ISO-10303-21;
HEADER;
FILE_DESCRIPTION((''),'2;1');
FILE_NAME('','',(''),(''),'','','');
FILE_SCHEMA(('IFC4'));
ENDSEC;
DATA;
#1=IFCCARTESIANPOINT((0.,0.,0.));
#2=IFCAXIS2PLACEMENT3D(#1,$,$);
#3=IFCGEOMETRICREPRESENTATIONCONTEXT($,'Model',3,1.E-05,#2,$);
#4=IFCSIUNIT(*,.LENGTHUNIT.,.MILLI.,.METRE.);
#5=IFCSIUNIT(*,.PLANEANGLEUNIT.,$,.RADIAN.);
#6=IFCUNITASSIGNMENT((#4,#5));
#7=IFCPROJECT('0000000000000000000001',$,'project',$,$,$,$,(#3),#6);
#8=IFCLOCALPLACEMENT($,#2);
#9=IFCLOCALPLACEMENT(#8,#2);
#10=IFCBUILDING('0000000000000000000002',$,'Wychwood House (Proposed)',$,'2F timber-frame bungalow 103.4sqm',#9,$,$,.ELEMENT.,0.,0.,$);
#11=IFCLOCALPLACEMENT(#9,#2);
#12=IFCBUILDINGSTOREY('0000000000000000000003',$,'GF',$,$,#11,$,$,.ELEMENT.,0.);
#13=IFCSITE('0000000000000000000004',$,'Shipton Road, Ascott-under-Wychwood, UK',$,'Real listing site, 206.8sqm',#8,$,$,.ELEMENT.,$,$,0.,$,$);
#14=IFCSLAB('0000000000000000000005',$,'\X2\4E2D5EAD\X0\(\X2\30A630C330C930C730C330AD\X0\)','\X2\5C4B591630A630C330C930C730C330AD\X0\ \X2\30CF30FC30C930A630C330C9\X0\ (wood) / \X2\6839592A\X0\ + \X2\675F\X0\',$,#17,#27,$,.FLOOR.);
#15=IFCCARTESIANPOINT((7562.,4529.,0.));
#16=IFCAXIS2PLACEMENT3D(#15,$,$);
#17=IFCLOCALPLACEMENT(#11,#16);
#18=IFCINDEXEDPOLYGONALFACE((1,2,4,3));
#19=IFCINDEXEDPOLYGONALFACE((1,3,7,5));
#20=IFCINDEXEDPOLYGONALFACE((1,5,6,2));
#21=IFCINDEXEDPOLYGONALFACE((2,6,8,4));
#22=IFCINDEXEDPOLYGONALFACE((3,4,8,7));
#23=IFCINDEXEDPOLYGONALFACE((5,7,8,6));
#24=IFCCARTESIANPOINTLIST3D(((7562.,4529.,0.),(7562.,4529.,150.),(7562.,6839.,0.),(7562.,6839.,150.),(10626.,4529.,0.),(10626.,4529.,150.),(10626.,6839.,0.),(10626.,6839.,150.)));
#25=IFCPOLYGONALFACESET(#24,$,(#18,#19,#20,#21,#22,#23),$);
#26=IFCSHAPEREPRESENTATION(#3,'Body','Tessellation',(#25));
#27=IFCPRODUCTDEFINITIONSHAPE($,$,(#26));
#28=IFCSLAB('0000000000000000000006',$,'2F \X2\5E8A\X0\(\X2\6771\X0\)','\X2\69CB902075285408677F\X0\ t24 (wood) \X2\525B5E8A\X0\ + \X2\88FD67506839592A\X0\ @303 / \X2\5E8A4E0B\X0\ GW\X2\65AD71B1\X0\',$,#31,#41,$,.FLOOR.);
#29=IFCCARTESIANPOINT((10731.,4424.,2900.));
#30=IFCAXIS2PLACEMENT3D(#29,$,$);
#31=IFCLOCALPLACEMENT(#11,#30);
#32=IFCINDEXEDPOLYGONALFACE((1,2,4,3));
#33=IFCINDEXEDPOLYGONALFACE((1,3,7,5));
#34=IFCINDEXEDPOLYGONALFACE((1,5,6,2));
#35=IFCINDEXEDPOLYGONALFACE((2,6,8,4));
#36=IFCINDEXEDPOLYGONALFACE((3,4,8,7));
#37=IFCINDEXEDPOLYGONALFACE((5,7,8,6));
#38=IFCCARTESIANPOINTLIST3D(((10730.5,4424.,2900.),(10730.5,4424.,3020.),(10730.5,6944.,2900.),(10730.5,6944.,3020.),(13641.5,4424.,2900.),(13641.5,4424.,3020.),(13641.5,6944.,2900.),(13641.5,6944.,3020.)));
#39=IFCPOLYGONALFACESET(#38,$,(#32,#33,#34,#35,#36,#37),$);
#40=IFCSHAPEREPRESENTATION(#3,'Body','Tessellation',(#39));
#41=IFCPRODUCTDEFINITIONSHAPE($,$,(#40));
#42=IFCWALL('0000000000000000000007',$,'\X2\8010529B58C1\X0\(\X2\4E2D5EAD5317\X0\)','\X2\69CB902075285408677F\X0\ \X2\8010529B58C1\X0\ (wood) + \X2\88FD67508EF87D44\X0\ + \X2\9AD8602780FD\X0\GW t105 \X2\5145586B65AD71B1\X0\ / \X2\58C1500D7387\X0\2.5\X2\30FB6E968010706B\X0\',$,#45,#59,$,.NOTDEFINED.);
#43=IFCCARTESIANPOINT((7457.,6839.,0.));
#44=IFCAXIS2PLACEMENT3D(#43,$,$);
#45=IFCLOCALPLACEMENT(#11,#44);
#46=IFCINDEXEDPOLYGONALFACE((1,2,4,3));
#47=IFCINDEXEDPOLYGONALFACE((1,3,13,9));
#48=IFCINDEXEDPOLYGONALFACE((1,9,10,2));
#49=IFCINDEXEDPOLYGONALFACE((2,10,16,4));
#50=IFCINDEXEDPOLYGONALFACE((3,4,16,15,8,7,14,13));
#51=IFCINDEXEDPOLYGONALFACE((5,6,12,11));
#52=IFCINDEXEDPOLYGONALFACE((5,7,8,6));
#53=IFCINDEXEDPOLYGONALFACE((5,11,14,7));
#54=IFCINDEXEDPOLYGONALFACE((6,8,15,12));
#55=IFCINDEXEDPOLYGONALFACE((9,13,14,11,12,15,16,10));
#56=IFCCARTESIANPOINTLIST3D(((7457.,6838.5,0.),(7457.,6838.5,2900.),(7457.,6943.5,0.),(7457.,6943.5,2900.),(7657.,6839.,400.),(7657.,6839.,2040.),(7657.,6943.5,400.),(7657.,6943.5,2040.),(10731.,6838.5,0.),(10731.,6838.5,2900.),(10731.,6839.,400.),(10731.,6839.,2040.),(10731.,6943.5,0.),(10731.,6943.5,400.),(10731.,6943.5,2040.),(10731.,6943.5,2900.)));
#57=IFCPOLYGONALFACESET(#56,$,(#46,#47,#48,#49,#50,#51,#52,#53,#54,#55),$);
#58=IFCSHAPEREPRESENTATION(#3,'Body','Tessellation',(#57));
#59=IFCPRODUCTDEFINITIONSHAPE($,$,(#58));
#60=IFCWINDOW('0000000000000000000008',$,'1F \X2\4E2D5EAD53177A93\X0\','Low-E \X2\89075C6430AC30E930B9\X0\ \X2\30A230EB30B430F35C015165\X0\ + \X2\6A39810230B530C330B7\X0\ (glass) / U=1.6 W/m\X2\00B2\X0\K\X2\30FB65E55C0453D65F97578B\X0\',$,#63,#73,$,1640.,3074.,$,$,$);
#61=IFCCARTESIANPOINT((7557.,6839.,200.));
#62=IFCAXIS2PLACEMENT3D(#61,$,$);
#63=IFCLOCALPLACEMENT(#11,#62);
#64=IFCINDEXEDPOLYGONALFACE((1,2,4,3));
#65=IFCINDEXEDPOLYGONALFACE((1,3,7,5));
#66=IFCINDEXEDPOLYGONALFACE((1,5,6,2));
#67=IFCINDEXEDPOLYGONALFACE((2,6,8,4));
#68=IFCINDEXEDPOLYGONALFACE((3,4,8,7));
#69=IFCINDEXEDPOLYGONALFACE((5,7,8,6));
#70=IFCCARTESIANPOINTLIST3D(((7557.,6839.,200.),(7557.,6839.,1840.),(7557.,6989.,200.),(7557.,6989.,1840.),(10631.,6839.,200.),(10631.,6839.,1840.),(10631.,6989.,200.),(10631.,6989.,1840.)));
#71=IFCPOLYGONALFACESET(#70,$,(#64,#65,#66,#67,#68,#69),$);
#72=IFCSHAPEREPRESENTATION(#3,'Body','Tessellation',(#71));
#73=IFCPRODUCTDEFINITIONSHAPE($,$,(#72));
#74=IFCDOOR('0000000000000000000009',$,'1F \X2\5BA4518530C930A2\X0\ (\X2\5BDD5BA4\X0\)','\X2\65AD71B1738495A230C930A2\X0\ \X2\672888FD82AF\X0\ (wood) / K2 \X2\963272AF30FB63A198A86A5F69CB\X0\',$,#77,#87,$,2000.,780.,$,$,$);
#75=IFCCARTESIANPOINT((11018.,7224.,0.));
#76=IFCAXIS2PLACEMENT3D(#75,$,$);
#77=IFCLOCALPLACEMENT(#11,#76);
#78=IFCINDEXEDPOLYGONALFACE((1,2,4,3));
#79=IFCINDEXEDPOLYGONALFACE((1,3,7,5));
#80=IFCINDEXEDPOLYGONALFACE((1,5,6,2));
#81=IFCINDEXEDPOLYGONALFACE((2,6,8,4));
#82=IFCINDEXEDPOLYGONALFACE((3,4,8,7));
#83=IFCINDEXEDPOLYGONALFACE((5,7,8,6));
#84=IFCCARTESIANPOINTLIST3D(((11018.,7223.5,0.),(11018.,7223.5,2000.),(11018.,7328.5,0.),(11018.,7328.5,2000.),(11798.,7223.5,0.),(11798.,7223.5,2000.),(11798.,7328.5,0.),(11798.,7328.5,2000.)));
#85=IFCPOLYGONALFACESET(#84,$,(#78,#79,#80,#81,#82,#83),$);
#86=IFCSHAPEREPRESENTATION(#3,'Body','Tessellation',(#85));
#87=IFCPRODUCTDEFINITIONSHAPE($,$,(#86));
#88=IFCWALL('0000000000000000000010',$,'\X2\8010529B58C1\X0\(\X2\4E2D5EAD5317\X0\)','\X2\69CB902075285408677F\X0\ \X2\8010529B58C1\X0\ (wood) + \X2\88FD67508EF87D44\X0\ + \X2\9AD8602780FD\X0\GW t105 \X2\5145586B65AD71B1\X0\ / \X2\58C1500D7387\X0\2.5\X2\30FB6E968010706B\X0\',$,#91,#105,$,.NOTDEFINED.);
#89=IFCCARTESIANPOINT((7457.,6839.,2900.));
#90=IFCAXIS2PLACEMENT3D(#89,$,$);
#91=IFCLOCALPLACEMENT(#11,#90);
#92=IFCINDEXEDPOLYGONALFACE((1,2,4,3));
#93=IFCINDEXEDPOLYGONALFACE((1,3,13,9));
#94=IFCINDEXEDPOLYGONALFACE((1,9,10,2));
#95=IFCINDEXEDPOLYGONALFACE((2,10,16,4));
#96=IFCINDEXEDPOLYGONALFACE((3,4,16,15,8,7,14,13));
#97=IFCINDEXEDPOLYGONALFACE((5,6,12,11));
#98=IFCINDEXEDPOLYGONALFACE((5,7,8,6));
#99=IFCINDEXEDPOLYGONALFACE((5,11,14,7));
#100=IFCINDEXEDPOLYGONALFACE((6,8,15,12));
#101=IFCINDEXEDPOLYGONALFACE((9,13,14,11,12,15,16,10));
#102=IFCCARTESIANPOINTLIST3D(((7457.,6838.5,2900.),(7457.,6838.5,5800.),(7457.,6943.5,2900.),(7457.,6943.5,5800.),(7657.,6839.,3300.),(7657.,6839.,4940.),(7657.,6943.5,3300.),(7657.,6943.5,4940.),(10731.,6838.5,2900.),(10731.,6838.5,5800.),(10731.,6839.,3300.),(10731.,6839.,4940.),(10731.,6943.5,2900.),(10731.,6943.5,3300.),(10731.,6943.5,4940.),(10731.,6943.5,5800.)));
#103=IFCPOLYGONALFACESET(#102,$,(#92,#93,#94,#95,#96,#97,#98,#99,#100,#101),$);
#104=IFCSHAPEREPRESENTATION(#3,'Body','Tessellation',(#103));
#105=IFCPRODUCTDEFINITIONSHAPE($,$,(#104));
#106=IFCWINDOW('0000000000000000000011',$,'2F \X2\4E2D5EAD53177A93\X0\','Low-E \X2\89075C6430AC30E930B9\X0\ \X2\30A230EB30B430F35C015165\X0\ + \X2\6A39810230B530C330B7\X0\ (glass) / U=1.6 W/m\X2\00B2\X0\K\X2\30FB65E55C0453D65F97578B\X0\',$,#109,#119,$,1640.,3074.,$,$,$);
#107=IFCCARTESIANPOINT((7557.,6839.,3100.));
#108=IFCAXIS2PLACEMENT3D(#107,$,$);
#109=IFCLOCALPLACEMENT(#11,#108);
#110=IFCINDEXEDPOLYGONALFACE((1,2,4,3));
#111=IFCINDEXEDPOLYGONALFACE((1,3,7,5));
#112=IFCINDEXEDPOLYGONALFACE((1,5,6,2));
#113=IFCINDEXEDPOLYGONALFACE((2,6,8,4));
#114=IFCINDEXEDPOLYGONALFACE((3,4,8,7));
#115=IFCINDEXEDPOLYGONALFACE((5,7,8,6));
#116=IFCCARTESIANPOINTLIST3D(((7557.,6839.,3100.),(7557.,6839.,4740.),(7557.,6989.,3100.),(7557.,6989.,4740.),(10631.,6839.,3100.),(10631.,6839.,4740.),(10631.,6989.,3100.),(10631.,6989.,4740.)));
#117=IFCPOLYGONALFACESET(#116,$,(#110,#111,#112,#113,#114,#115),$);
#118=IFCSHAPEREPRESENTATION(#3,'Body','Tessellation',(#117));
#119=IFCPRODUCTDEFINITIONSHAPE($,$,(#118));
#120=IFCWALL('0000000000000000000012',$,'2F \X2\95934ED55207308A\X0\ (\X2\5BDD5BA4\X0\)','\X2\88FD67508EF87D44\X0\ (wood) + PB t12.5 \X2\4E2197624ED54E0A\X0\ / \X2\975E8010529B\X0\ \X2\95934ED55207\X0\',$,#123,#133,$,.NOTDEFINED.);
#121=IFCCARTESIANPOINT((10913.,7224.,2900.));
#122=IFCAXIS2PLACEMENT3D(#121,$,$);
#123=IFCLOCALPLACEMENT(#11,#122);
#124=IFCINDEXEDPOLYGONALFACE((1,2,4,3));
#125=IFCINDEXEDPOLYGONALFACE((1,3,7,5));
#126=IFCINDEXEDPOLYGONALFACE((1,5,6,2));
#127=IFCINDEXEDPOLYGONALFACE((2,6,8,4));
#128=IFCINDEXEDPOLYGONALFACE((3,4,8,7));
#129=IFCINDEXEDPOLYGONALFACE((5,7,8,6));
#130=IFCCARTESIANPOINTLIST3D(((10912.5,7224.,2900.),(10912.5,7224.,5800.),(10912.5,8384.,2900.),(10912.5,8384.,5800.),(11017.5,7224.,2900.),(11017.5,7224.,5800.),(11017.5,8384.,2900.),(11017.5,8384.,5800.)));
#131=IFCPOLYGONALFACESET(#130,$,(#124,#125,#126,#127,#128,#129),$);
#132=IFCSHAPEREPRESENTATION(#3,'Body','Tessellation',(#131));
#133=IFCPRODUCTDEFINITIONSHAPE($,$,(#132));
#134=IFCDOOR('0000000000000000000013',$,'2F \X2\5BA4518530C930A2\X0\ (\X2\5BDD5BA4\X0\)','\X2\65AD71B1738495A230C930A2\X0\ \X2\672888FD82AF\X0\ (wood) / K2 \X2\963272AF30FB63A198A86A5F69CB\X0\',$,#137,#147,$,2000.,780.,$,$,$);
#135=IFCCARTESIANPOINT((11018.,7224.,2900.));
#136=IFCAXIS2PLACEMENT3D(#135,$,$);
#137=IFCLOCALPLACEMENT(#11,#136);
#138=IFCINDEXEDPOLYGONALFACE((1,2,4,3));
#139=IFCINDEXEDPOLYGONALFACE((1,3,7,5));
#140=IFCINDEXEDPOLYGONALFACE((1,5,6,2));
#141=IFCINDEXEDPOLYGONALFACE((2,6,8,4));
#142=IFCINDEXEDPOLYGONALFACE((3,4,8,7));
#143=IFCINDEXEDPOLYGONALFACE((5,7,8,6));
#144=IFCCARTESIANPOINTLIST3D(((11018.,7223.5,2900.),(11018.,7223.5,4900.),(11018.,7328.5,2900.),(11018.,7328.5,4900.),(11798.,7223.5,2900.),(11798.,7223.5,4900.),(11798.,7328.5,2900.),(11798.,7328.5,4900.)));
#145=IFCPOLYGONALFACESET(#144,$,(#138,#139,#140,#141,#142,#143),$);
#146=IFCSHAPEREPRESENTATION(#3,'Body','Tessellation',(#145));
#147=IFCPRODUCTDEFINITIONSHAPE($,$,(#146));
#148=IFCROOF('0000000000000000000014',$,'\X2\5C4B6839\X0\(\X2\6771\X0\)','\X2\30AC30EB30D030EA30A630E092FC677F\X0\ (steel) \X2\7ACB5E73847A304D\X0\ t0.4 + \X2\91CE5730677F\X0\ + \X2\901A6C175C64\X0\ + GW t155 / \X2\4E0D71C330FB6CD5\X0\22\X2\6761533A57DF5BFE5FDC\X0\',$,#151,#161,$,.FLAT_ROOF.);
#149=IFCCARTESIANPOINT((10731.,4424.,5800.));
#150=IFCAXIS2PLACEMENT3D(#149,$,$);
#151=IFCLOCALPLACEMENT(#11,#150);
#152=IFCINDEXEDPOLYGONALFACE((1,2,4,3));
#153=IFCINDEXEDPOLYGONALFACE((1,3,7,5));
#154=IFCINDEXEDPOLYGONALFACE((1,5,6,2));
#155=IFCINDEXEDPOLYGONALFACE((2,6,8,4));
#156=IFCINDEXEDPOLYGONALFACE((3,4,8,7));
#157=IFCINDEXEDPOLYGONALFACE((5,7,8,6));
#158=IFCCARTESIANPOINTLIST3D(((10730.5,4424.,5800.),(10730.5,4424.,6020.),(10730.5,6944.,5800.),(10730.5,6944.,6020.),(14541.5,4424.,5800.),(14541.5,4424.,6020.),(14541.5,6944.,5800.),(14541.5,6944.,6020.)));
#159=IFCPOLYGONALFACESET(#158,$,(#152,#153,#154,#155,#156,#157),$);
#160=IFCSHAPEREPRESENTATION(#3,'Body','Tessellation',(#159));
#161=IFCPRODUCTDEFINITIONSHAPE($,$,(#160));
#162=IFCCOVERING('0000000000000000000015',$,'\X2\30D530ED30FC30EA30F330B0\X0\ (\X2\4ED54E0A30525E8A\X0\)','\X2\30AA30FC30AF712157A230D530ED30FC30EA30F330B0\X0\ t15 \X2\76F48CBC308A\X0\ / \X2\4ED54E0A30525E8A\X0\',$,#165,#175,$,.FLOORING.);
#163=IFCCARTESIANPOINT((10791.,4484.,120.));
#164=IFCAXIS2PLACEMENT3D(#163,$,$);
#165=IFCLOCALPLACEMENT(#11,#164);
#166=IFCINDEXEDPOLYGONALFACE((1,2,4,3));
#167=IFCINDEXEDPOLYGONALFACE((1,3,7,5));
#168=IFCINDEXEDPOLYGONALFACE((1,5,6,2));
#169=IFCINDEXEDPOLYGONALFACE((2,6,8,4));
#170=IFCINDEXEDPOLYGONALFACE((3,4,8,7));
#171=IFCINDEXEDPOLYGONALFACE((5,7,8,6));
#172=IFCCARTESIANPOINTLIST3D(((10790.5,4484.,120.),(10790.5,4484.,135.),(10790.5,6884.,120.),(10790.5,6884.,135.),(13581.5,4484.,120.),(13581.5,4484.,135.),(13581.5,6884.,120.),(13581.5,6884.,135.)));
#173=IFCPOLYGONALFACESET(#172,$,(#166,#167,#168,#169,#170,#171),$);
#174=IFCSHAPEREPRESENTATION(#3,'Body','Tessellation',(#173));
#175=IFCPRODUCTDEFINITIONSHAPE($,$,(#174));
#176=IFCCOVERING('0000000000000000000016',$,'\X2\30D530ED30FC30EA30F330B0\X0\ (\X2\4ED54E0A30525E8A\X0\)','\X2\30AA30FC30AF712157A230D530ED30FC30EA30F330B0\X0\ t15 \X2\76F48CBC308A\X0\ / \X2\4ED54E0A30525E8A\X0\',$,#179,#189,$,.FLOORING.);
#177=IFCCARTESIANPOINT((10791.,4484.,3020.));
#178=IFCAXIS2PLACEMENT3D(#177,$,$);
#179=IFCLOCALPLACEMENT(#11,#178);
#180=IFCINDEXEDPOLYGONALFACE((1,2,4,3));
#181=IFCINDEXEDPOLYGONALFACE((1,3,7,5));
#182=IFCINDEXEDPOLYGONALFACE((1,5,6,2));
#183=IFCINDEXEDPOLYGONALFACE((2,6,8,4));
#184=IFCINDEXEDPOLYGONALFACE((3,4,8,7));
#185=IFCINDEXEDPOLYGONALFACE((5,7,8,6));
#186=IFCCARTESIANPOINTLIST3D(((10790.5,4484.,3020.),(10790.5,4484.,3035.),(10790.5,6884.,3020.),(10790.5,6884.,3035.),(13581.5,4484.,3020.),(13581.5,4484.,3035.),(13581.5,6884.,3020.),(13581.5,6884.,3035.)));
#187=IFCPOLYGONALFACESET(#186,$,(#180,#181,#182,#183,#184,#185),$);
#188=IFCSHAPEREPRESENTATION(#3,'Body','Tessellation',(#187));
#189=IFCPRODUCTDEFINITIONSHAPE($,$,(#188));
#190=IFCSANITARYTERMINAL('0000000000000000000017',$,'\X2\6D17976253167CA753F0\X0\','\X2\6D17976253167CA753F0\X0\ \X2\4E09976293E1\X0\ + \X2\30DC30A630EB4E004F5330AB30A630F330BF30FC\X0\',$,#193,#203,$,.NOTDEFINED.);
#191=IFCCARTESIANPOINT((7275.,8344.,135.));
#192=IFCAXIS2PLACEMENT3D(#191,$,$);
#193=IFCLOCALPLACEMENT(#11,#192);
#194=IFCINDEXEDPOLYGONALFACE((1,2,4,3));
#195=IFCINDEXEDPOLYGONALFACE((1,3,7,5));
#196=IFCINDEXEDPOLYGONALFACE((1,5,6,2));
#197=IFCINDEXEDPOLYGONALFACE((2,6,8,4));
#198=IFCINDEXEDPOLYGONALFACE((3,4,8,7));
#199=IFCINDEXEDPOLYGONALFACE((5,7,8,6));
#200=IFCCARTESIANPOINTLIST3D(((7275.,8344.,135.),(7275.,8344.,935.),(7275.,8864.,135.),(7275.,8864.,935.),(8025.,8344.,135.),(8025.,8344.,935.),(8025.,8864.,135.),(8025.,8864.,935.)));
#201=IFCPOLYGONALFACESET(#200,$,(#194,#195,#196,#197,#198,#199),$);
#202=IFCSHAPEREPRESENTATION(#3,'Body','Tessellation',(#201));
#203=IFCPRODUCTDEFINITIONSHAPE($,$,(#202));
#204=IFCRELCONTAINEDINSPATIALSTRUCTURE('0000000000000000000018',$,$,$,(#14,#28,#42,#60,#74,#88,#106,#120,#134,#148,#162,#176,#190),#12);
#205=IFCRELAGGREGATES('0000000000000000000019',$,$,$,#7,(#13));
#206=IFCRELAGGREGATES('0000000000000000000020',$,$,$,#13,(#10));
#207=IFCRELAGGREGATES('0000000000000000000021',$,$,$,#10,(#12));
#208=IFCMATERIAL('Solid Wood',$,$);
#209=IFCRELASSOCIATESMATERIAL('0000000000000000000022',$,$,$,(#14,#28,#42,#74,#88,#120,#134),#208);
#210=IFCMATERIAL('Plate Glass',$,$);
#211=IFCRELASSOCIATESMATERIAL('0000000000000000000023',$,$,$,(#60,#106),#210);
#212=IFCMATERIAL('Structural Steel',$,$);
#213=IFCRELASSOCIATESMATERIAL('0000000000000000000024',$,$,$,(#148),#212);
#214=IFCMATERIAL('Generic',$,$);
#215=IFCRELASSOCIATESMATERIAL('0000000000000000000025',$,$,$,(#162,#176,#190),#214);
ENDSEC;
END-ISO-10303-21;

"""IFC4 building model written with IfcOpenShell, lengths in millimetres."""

from ifc_helpers import new_model, si_unit, frame, frame_2d, origin, place, context, project, spatial, rectangle, extrude, material, element, fill, save


model = new_model("IFC4")

# Units and contexts
model_context = context("Model", 3, precision=1e-05, world=origin())
ifc_project = project(units=[si_unit("LENGTHUNIT", "METRE", prefix="MILLI"), si_unit("PLANEANGLEUNIT", "RADIAN")], contexts=[model_context])

# Site, building, storey
site_placement = place(None, origin())
site = spatial("IfcSite", under=ifc_project, at=site_placement, Name="Shipton Road, Ascott-under-Wychwood, UK", ObjectType="Real listing site, 206.8sqm", CompositionType="ELEMENT", RefElevation=0.0)
building_placement = place(site_placement, origin())
building = spatial("IfcBuilding", under=site, at=building_placement, Name="Wychwood House (Proposed)", ObjectType="2F timber-frame bungalow 103.4sqm", CompositionType="ELEMENT", ElevationOfRefHeight=0.0, ElevationOfTerrain=0.0)
storey_placement = place(building_placement, origin())
storey = spatial("IfcBuildingStorey", under=building, at=storey_placement, Name="GF", CompositionType="ELEMENT", Elevation=0.0)

# Slabs
ifc_material_1 = material(Name="Solid Wood")
slab_1_placement = place(storey_placement, frame((7562.0, 4529.0, 0.0)))
element("IfcSlab", 1, at=slab_1_placement, inside=storey, material=ifc_material_1, Name="中庭(ウッドデッキ)", Description="屋外ウッドデッキ ハードウッド (wood) / 根太 + 束", PredefinedType="FLOOR", context=model_context, shape_type="SweptSolid", body=[
    extrude(rectangle(XDim=3064.0, YDim=2310.0, at=frame_2d((1532.0, 1155.0))), frame((7562.0, 4529.0, 0.0)), (0.0, 0.0, 1.0), 150.0),
])
slab_2_placement = place(storey_placement, frame((10731.0, 4424.0, 2900.0)))
element("IfcSlab", 2, at=slab_2_placement, inside=storey, material=ifc_material_1, Name="2F 床(東)", Description="構造用合板 t24 (wood) 剛床 + 製材根太 @303 / 床下 GW断熱", PredefinedType="FLOOR", context=model_context, shape_type="SweptSolid", body=[
    extrude(rectangle(XDim=2911.0, YDim=2520.0, at=frame_2d((1455.0, 1260.0))), frame((10731.0, 4424.0, 2900.0)), (0.0, 0.0, 1.0), 120.0),
])

# Wall, opening, window
wall_1_placement = place(storey_placement, frame((7457.0, 6839.0, 0.0)))
wall_1 = element("IfcWall", 3, at=wall_1_placement, inside=storey, material=ifc_material_1, Name="耐力壁(中庭北)", Description="構造用合板 耐力壁 (wood) + 製材軸組 + 高性能GW t105 充填断熱 / 壁倍率2.5・準耐火", PredefinedType="NOTDEFINED", context=model_context, shape_type="SweptSolid", body=[
    extrude(rectangle(XDim=3274.0, YDim=105.0, at=frame_2d((1637.0, 52.0))), frame((7457.0, 6839.0, 0.0)), (0.0, 0.0, 1.0), 2900.0),
])
opening_1_placement = place(storey_placement, frame((7557.0, 6839.0, 200.0)))
opening_1 = element("IfcOpeningElement", 4, at=opening_1_placement, cuts=wall_1, PredefinedType="NOTDEFINED", context=model_context, shape_type="SweptSolid", body=[
    extrude(rectangle(XDim=3074.0, YDim=150.0, at=frame_2d((1537.0, 75.0))), frame((7557.0, 6839.0, 200.0)), (0.0, 0.0, 1.0), 1640.0),
])
ifc_material_2 = material(Name="Plate Glass")
window_1_placement = place(storey_placement, frame((7557.0, 6839.0, 200.0)))
window_1 = element("IfcWindow", 5, at=window_1_placement, inside=storey, material=ifc_material_2, Name="1F 中庭北窓", Description="Low-E 複層ガラス アルゴン封入 + 樹脂サッシ (glass) / U=1.6 W/m²K・日射取得型", OverallHeight=1640.0, OverallWidth=3074.0, context=model_context, shape_type="SweptSolid", body=[
    extrude(rectangle(XDim=3074.0, YDim=150.0, at=frame_2d((1537.0, 75.0))), frame((7557.0, 6839.0, 200.0)), (0.0, 0.0, 1.0), 1640.0),
])
fill(opening_1, window_1)

# Door
door_1_placement = place(storey_placement, frame((11018.0, 7224.0, 0.0)))
element("IfcDoor", 6, at=door_1_placement, inside=storey, material=ifc_material_1, Name="1F 室内ドア (寝室)", Description="断熱玄関ドア 木製芯 (wood) / K2 防犯・採風機構", OverallHeight=2000.0, OverallWidth=780.0, context=model_context, shape_type="SweptSolid", body=[
    extrude(rectangle(XDim=780.0, YDim=105.0, at=frame_2d((390.0, 52.0))), frame((11018.0, 7224.0, 0.0)), (0.0, 0.0, 1.0), 2000.0),
])

# Wall, opening, window
wall_2_placement = place(storey_placement, frame((7457.0, 6839.0, 2900.0)))
wall_2 = element("IfcWall", 7, at=wall_2_placement, inside=storey, material=ifc_material_1, Name="耐力壁(中庭北)", Description="構造用合板 耐力壁 (wood) + 製材軸組 + 高性能GW t105 充填断熱 / 壁倍率2.5・準耐火", PredefinedType="NOTDEFINED", context=model_context, shape_type="SweptSolid", body=[
    extrude(rectangle(XDim=3274.0, YDim=105.0, at=frame_2d((1637.0, 52.0))), frame((7457.0, 6839.0, 2900.0)), (0.0, 0.0, 1.0), 2900.0),
])
opening_2_placement = place(storey_placement, frame((7557.0, 6839.0, 3100.0)))
opening_2 = element("IfcOpeningElement", 8, at=opening_2_placement, cuts=wall_2, PredefinedType="NOTDEFINED", context=model_context, shape_type="SweptSolid", body=[
    extrude(rectangle(XDim=3074.0, YDim=150.0, at=frame_2d((1537.0, 75.0))), frame((7557.0, 6839.0, 3100.0)), (0.0, 0.0, 1.0), 1640.0),
])
window_2_placement = place(storey_placement, frame((7557.0, 6839.0, 3100.0)))
window_2 = element("IfcWindow", 9, at=window_2_placement, inside=storey, material=ifc_material_2, Name="2F 中庭北窓", Description="Low-E 複層ガラス アルゴン封入 + 樹脂サッシ (glass) / U=1.6 W/m²K・日射取得型", OverallHeight=1640.0, OverallWidth=3074.0, context=model_context, shape_type="SweptSolid", body=[
    extrude(rectangle(XDim=3074.0, YDim=150.0, at=frame_2d((1537.0, 75.0))), frame((7557.0, 6839.0, 3100.0)), (0.0, 0.0, 1.0), 1640.0),
])
fill(opening_2, window_2)

# Wall
wall_3_placement = place(storey_placement, frame((10913.0, 7224.0, 2900.0)))
element("IfcWall", 10, at=wall_3_placement, inside=storey, material=ifc_material_1, Name="2F 間仕切り (寝室)", Description="製材軸組 (wood) + PB t12.5 両面仕上 / 非耐力 間仕切", PredefinedType="NOTDEFINED", context=model_context, shape_type="SweptSolid", body=[
    extrude(rectangle(XDim=105.0, YDim=1160.0, at=frame_2d((52.0, 580.0))), frame((10913.0, 7224.0, 2900.0)), (0.0, 0.0, 1.0), 2900.0),
])

# Door
door_2_placement = place(storey_placement, frame((11018.0, 7224.0, 2900.0)))
element("IfcDoor", 11, at=door_2_placement, inside=storey, material=ifc_material_1, Name="2F 室内ドア (寝室)", Description="断熱玄関ドア 木製芯 (wood) / K2 防犯・採風機構", OverallHeight=2000.0, OverallWidth=780.0, context=model_context, shape_type="SweptSolid", body=[
    extrude(rectangle(XDim=780.0, YDim=105.0, at=frame_2d((390.0, 52.0))), frame((11018.0, 7224.0, 2900.0)), (0.0, 0.0, 1.0), 2000.0),
])

# Roof
ifc_material_3 = material(Name="Structural Steel")
for number, where, name in (
    (12, (10731.0, 4424.0, 5800.0), "屋根(東)"),
):
    element("IfcRoof", number, at=place(storey_placement, frame(where)), inside=storey, material=ifc_material_3, Name=name, Description="ガルバリウム鋼板 (steel) 立平葺き t0.4 + 野地板 + 通気層 + GW t155 / 不燃・法22条区域対応", PredefinedType="FLAT_ROOF", context=model_context, shape_type="SweptSolid", body=[
        extrude(rectangle(XDim=3811.0, YDim=2520.0, at=frame_2d((1905.0, 1260.0))), frame((10731.0, 4424.0, 5800.0)), (0.0, 0.0, 1.0), 220.0),
    ])

# Coverings
ifc_material_4 = material(Name="Generic")
covering_1_placement = place(storey_placement, frame((10791.0, 4484.0, 120.0)))
element("IfcCovering", 13, at=covering_1_placement, inside=storey, material=ifc_material_4, Name="フローリング (仕上げ床)", Description="オーク無垢フローリング t15 直貼り / 仕上げ床", PredefinedType="FLOORING", context=model_context, shape_type="SweptSolid", body=[
    extrude(rectangle(XDim=2791.0, YDim=2400.0, at=frame_2d((1395.0, 1200.0))), frame((10791.0, 4484.0, 120.0)), (0.0, 0.0, 1.0), 15.0),
])
covering_2_placement = place(storey_placement, frame((10791.0, 4484.0, 3020.0)))
element("IfcCovering", 14, at=covering_2_placement, inside=storey, material=ifc_material_4, Name="フローリング (仕上げ床)", Description="オーク無垢フローリング t15 直貼り / 仕上げ床", PredefinedType="FLOORING", context=model_context, shape_type="SweptSolid", body=[
    extrude(rectangle(XDim=2791.0, YDim=2400.0, at=frame_2d((1395.0, 1200.0))), frame((10791.0, 4484.0, 3020.0)), (0.0, 0.0, 1.0), 15.0),
])

# Sanitary terminal
sanitary_terminal_1_placement = place(storey_placement, frame((7275.0, 8344.0, 135.0)))
element("IfcSanitaryTerminal", 15, at=sanitary_terminal_1_placement, inside=storey, material=ifc_material_4, Name="洗面化粧台", Description="洗面化粧台 三面鏡 + ボウル一体カウンター", PredefinedType="NOTDEFINED", context=model_context, shape_type="SweptSolid", body=[
    extrude(rectangle(XDim=750.0, YDim=520.0, at=frame_2d((375.0, 260.0))), frame((7275.0, 8344.0, 135.0)), (0.0, 0.0, 1.0), 800.0),
])

save(model, "model.ifc")
